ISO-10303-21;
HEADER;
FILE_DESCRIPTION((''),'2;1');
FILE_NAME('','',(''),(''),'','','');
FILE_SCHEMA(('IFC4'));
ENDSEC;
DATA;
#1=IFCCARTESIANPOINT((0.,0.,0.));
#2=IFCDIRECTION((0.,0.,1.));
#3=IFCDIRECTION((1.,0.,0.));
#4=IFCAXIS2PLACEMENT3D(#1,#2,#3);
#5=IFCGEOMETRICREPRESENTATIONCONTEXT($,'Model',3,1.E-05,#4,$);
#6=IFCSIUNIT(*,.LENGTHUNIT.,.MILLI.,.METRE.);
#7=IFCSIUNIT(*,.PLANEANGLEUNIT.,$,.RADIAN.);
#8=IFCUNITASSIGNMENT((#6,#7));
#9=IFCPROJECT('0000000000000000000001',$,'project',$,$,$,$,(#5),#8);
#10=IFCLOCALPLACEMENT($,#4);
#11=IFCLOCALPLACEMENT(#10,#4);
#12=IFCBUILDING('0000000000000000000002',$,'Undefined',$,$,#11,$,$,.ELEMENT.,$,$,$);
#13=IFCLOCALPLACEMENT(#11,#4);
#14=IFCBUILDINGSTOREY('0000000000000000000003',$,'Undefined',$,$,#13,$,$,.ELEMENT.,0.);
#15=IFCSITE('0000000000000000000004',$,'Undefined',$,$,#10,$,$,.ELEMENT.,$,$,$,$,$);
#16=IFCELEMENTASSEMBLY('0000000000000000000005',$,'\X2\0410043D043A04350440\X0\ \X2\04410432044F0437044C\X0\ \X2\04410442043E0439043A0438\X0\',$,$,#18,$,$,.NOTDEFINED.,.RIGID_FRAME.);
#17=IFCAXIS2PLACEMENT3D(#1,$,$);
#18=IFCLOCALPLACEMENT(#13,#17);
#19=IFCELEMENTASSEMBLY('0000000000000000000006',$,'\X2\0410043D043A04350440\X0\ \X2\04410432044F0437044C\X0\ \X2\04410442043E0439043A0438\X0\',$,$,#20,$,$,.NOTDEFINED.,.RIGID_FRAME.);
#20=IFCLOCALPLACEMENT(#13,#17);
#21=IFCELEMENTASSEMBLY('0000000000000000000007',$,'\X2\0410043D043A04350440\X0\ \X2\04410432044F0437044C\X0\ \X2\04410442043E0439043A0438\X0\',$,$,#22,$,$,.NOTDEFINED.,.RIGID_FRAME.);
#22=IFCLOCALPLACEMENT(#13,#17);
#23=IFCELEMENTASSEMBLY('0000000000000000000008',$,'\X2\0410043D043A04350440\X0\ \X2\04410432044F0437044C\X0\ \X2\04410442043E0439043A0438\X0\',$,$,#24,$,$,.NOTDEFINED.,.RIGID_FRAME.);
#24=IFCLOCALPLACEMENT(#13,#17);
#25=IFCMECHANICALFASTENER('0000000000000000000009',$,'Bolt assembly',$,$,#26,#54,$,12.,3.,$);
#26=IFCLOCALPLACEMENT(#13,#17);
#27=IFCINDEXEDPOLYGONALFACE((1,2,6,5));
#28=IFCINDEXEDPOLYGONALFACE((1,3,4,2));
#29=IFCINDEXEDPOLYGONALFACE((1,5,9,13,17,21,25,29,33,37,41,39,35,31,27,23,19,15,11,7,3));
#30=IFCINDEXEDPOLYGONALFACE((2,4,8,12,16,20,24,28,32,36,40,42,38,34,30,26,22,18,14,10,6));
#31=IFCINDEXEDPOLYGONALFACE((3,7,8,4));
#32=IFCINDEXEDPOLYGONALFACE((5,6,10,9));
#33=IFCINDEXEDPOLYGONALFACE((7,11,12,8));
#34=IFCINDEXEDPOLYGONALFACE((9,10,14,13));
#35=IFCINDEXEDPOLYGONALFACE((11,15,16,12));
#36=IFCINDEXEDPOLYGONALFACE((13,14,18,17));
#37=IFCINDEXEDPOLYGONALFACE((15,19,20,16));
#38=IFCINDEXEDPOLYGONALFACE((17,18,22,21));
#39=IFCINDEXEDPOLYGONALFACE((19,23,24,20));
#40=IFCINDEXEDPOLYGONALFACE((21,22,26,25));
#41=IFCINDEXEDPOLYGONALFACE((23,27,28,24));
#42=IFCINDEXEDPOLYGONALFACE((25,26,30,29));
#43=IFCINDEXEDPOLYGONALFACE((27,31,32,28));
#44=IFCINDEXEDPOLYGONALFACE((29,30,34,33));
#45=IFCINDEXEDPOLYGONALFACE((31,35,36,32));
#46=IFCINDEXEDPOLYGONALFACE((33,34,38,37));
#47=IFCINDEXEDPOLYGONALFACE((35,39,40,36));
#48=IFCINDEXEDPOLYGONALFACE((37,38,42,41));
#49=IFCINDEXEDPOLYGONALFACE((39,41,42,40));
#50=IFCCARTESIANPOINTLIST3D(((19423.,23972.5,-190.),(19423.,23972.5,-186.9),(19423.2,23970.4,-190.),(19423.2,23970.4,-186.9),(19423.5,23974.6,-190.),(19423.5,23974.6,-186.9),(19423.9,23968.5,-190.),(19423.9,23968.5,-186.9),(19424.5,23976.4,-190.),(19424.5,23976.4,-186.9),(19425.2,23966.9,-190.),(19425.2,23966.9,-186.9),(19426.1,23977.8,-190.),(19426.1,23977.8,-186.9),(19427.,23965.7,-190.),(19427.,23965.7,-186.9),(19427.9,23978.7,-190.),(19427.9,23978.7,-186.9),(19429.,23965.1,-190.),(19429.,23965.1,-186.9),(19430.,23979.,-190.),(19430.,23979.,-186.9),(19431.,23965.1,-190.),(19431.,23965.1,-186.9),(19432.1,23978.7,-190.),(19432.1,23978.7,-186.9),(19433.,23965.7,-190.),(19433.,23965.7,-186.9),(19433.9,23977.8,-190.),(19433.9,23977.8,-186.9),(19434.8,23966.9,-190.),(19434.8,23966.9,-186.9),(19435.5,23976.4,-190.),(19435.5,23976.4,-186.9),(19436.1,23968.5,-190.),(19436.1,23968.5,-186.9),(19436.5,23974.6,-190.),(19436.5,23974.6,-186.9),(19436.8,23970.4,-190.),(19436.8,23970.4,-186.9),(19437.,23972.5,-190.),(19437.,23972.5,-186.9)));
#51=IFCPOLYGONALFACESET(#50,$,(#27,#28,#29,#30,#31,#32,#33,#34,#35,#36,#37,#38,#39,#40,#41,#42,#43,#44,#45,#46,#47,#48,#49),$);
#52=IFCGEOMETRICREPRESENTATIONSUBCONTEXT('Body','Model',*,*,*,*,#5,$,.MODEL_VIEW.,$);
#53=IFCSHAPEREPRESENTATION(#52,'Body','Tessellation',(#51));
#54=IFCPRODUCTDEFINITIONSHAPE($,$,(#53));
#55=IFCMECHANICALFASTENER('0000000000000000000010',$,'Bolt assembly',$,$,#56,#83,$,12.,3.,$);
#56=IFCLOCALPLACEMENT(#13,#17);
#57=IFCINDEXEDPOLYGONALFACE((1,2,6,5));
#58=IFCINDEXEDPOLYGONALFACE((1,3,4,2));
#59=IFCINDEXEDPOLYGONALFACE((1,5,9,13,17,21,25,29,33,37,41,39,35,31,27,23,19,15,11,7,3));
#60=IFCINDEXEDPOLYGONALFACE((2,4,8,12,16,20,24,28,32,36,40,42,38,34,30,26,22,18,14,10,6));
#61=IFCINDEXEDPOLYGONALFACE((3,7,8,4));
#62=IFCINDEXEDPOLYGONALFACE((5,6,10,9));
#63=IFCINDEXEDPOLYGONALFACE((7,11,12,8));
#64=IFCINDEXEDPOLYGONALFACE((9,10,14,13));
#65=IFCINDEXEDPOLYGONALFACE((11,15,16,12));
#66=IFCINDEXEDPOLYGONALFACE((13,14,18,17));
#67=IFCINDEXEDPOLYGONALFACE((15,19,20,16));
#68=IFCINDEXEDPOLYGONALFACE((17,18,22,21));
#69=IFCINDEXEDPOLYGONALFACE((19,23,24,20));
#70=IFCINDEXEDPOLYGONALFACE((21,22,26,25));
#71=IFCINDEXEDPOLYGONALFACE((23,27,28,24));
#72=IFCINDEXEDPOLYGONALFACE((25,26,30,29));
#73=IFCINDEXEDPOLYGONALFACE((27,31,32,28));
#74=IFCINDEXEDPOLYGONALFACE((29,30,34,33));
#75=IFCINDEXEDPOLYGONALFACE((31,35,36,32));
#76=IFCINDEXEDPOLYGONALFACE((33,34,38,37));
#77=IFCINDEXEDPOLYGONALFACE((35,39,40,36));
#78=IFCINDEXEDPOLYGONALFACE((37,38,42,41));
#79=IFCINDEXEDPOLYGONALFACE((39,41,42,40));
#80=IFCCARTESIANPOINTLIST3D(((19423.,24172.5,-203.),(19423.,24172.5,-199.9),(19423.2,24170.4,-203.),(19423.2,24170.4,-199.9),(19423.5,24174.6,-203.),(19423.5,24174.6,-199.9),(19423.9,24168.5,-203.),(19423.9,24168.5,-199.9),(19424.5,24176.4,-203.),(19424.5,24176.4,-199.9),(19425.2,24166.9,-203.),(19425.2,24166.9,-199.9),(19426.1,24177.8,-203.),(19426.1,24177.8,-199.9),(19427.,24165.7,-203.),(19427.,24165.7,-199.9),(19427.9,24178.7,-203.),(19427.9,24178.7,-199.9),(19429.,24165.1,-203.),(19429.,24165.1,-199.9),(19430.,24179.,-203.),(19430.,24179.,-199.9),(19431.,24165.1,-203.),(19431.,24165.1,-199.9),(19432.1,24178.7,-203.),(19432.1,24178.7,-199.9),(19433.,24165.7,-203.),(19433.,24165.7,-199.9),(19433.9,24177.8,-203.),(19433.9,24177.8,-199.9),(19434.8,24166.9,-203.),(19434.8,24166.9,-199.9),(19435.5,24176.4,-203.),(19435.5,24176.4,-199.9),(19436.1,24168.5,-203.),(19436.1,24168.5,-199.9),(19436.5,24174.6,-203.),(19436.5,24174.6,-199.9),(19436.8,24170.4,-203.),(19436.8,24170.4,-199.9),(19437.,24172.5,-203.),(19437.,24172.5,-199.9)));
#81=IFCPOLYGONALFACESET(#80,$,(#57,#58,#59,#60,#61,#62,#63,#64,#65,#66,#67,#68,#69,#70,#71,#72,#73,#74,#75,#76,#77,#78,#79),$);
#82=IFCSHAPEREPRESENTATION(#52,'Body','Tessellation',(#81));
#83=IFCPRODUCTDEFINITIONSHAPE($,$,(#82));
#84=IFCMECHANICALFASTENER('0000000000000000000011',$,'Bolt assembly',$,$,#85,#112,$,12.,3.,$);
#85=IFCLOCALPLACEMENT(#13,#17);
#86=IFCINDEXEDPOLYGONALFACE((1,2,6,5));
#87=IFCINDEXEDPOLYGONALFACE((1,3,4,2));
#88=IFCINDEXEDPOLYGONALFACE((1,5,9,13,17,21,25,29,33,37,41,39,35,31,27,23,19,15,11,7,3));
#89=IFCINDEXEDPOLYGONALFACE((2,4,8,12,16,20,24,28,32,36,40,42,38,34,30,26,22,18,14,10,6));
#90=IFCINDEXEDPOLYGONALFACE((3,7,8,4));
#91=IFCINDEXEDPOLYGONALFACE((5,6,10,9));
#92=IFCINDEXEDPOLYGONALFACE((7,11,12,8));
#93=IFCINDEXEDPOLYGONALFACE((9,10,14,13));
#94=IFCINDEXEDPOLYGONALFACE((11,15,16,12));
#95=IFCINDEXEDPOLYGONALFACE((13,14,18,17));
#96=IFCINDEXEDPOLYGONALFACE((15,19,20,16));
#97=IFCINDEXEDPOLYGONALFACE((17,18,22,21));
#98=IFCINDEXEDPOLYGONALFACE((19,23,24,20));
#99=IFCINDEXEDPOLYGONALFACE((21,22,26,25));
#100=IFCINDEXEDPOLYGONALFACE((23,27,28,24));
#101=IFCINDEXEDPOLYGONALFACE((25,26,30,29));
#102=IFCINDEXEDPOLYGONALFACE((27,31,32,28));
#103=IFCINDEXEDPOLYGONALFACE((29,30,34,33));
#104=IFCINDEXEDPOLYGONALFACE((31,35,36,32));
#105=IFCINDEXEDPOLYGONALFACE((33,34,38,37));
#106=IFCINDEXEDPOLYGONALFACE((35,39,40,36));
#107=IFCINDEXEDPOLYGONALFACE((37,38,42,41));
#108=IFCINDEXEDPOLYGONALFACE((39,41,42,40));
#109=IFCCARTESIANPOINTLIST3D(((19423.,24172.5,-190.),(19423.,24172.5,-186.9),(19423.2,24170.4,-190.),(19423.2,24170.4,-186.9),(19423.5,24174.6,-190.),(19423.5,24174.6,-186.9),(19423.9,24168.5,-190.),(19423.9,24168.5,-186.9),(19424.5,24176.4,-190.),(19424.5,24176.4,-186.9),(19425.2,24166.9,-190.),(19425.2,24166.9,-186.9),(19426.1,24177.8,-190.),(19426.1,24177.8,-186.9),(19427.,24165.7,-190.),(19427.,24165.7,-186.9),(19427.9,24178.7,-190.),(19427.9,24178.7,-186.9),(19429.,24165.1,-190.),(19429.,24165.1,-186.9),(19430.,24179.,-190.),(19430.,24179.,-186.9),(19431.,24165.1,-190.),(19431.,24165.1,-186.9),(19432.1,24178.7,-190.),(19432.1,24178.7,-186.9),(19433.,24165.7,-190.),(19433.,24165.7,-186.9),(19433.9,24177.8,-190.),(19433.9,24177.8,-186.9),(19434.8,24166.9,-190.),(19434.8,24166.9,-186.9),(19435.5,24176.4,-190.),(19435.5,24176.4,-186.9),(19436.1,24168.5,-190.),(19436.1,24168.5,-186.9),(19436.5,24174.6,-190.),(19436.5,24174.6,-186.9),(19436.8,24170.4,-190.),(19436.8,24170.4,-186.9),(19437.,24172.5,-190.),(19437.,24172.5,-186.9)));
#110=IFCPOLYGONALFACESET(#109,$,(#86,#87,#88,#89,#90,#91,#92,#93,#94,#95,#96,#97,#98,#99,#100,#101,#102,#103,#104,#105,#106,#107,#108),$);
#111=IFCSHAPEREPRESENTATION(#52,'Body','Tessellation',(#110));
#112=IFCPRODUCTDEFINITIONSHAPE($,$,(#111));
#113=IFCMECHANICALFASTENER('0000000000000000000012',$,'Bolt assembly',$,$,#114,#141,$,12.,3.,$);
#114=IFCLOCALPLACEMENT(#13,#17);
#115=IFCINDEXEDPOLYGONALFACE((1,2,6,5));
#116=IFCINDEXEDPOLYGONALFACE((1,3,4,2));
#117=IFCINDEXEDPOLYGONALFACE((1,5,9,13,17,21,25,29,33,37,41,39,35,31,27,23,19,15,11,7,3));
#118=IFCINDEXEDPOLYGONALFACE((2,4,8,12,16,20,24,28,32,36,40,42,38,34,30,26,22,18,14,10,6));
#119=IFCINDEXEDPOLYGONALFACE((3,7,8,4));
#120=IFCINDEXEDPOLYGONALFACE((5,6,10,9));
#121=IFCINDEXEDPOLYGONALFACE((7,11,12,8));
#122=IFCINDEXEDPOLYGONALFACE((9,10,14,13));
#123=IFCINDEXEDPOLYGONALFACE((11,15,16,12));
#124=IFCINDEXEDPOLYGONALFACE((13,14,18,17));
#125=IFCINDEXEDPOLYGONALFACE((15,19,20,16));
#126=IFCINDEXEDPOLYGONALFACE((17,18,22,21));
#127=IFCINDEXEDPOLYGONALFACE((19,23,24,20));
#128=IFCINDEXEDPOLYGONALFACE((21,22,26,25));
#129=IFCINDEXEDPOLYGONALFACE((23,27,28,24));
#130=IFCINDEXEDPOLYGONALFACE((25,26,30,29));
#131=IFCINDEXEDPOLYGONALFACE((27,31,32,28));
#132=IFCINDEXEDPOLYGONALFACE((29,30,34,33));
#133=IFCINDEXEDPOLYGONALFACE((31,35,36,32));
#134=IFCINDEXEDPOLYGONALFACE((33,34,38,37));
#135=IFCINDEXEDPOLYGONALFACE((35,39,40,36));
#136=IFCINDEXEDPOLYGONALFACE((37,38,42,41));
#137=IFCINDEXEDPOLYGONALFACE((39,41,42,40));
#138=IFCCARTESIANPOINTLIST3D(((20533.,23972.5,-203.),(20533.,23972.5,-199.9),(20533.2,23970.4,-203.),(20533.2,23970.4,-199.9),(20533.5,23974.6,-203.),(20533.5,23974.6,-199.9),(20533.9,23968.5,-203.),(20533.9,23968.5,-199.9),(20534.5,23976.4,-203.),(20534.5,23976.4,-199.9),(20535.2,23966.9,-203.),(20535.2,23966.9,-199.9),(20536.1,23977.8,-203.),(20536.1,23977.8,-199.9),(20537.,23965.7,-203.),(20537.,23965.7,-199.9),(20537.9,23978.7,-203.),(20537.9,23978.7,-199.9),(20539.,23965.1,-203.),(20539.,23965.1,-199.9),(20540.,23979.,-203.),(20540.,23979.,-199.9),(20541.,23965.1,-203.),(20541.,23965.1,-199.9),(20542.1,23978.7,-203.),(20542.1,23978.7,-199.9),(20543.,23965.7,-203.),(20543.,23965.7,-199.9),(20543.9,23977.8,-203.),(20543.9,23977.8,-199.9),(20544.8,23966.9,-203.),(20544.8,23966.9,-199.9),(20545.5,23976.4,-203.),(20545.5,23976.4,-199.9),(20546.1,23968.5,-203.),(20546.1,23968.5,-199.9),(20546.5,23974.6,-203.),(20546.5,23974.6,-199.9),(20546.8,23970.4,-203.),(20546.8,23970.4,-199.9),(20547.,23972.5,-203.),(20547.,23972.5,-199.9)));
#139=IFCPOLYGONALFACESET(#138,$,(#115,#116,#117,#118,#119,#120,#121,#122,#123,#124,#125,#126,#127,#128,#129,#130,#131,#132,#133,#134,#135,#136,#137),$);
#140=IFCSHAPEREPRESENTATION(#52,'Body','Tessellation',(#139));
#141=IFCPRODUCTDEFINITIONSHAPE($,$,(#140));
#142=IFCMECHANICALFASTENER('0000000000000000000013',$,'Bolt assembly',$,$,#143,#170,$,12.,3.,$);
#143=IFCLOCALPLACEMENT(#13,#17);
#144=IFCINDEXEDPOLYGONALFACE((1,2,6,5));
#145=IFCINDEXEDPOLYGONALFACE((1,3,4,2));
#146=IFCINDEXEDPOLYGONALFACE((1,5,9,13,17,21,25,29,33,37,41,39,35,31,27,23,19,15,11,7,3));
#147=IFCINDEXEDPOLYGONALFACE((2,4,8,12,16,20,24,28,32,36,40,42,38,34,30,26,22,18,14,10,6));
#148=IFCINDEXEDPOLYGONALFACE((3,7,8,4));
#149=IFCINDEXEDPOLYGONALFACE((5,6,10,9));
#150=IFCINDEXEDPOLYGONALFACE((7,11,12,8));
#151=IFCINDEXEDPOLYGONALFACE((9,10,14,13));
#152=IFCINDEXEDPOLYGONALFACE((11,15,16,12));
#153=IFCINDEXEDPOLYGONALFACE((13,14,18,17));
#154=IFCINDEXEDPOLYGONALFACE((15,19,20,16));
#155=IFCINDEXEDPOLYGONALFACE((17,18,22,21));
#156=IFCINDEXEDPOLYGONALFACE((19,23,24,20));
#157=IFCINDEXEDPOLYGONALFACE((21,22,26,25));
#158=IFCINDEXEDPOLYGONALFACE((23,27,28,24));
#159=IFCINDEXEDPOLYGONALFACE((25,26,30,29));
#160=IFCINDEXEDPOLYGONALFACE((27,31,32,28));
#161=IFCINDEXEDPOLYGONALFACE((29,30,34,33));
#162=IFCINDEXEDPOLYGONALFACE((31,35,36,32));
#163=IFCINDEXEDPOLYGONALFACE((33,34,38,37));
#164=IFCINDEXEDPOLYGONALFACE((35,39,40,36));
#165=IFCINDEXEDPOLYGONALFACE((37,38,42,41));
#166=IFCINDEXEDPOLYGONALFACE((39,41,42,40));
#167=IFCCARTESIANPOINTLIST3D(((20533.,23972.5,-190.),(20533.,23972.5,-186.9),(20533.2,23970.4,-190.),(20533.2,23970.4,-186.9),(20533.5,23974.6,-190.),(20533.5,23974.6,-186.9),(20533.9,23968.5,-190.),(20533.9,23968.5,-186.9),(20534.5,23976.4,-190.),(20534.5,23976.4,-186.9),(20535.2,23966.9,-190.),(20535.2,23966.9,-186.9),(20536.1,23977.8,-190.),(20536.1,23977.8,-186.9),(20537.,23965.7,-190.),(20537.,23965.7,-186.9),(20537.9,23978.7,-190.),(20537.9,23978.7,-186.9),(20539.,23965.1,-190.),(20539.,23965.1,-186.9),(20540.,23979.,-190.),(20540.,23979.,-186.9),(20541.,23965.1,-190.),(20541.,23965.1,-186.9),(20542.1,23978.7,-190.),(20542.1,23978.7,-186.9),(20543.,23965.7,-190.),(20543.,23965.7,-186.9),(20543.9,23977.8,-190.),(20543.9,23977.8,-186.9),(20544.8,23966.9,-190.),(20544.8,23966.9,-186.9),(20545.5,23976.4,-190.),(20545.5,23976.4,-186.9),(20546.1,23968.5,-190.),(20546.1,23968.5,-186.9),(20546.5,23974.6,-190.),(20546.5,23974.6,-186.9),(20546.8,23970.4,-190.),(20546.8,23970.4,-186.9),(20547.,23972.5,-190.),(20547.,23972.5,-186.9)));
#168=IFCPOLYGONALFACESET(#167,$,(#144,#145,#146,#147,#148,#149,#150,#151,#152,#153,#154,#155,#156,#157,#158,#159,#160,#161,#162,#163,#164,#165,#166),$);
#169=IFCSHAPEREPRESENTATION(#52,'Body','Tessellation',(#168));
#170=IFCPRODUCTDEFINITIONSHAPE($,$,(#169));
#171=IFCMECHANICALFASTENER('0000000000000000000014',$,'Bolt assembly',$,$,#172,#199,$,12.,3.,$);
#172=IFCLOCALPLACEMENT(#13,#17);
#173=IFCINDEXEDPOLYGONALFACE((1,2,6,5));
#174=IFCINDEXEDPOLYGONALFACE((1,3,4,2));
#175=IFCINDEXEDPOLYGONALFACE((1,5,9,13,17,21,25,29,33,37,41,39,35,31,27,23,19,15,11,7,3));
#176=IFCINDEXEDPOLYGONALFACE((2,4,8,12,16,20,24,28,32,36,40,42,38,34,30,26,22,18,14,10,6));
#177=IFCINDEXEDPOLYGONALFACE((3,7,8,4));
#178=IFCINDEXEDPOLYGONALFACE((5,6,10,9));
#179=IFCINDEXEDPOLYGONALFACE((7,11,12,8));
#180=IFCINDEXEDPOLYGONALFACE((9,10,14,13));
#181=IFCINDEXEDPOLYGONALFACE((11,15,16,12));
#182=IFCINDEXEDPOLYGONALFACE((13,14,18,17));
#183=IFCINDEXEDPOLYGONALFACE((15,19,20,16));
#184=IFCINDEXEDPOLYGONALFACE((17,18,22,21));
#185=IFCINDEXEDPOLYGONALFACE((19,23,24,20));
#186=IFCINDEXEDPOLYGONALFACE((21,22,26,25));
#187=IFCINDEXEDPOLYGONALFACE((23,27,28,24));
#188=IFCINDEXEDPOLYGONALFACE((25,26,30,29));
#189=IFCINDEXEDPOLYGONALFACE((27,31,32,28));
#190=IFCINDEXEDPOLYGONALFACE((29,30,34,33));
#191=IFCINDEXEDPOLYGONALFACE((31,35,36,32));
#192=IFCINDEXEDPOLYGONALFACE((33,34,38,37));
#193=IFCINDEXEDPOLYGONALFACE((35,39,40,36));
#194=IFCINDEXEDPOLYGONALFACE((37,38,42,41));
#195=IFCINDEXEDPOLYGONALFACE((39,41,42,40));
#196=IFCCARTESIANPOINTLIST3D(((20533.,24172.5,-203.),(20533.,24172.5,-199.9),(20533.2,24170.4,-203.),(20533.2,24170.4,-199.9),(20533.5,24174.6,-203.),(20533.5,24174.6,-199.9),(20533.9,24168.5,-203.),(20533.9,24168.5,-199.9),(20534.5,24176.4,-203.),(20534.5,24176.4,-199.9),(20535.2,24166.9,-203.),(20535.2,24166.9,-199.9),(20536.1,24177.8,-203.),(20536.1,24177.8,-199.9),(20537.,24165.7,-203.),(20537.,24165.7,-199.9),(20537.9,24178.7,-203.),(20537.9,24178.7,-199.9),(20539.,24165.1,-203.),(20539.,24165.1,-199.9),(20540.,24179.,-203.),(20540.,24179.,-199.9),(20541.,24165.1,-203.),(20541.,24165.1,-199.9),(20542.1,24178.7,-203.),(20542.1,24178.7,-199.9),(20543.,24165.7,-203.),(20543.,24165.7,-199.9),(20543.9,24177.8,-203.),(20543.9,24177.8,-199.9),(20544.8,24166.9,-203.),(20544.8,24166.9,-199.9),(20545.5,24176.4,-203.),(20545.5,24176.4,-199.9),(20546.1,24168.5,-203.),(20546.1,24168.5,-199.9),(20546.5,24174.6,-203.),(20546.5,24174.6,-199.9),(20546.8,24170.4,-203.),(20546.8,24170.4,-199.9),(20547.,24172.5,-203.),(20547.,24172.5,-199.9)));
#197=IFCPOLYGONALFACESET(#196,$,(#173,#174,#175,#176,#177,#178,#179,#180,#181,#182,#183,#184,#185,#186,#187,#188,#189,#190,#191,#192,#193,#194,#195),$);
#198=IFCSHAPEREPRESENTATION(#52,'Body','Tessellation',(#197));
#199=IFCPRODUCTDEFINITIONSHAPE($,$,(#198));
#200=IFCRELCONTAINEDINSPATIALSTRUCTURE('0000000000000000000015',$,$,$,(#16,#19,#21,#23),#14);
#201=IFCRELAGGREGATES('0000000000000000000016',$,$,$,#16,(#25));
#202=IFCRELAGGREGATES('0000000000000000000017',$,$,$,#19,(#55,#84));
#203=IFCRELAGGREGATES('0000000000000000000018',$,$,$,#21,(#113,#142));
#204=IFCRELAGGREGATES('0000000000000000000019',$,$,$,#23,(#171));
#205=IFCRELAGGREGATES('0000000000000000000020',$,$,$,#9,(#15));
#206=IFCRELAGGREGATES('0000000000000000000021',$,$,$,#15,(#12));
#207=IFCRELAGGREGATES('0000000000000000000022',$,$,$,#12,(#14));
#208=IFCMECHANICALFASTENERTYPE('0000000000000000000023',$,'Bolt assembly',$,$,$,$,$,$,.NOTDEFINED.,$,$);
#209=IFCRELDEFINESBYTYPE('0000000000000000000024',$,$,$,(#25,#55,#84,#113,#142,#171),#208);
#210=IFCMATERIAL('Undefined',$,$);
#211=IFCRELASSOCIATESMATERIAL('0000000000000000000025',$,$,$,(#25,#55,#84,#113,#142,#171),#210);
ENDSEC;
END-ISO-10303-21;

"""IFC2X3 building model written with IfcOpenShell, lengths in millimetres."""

from ifc_helpers import new_model, si_unit, frame, origin_with_axes, origin_2d_with_axis, place, context, subcontext, project, spatial, circle, extrude, source, transform, mapped, material, type_object, element, aggregate, save


model = new_model("IFC2X3")

# Units and contexts
model_context = context("Model", 3, precision=1e-05, world=origin_with_axes())
body_context = subcontext(model_context, "Body", "Model", "MODEL_VIEW")
ifc_project = project(units=[si_unit("LENGTHUNIT", "METRE", prefix="MILLI"), si_unit("PLANEANGLEUNIT", "RADIAN")], contexts=[model_context])

# Site, building, storey
site_placement = place(None, origin_with_axes())
site = spatial("IfcSite", under=ifc_project, at=site_placement, Name="Undefined", CompositionType="ELEMENT")
building_placement = place(site_placement, origin_with_axes())
building = spatial("IfcBuilding", under=site, at=building_placement, Name="Undefined", CompositionType="ELEMENT")
storey_placement = place(building_placement, origin_with_axes())
storey = spatial("IfcBuildingStorey", under=building, at=storey_placement, Name="Undefined", CompositionType="ELEMENT", Elevation=0.0)

# Element assemblies
assembly_1_placement = place(storey_placement, origin_with_axes())
assembly_1 = element("IfcElementAssembly", 1, at=assembly_1_placement, inside=storey, Name="Анкер связь стойки", AssemblyPlace="NOTDEFINED", PredefinedType="RIGID_FRAME")
assembly_2_placement = place(storey_placement, origin_with_axes())
assembly_2 = element("IfcElementAssembly", 2, at=assembly_2_placement, inside=storey, Name="Анкер связь стойки", AssemblyPlace="NOTDEFINED", PredefinedType="RIGID_FRAME")
assembly_3_placement = place(storey_placement, origin_with_axes())
assembly_3 = element("IfcElementAssembly", 3, at=assembly_3_placement, inside=storey, Name="Анкер связь стойки", AssemblyPlace="NOTDEFINED", PredefinedType="RIGID_FRAME")
assembly_4_placement = place(storey_placement, origin_with_axes())
assembly_4 = element("IfcElementAssembly", 4, at=assembly_4_placement, inside=storey, Name="Анкер связь стойки", AssemblyPlace="NOTDEFINED", PredefinedType="RIGID_FRAME")

# Mechanical fasteners
ifc_material_1 = material(Name="Undefined")
mechanical_fastener_type = type_object("IfcMechanicalFastenerType", Name="Bolt assembly")
shared_shape_1 = source(origin_with_axes(), body_context, "Body", "SweptSolid", [
    extrude(circle(Radius=7.0, at=origin_2d_with_axis()), frame((0.0, -3.0, 0.0), z_axis=(0.0, 1.0, 0.0), x_axis=(1.0, 0.0, 0.0)), (0.0, 0.0, 1.0), 3.1),
])
mechanical_fastener_1_placement = place(assembly_1_placement, frame((19430.0, 23972.0, -187.0), z_axis=(1.0, 0.0, 0.0), x_axis=(0.0, 1.0, 0.0)))
mechanical_fastener_1 = element("IfcMechanicalFastener", 5, at=mechanical_fastener_1_placement, type_object=mechanical_fastener_type, material=ifc_material_1, Name="Bolt assembly", NominalDiameter=12.0, NominalLength=3.0, context=body_context, shape_type="MappedRepresentation", body=[
    mapped(shared_shape_1, transform((0.0, 0.0, 0.0))),
])
aggregate(assembly_1, [mechanical_fastener_1])
mechanical_fastener_2_placement = place(assembly_2_placement, frame((19430.0, 24172.0, -200.0), z_axis=(1.0, 0.0, 0.0), x_axis=(0.0, 1.0, 0.0)))
mechanical_fastener_2 = element("IfcMechanicalFastener", 6, at=mechanical_fastener_2_placement, type_object=mechanical_fastener_type, material=ifc_material_1, Name="Bolt assembly", NominalDiameter=12.0, NominalLength=3.0, context=body_context, shape_type="MappedRepresentation", body=[
    mapped(shared_shape_1, transform((0.0, 0.0, 0.0))),
])
mechanical_fastener_3_placement = place(assembly_2_placement, frame((19430.0, 24172.0, -187.0), z_axis=(1.0, 0.0, 0.0), x_axis=(0.0, 1.0, 0.0)))
mechanical_fastener_3 = element("IfcMechanicalFastener", 7, at=mechanical_fastener_3_placement, type_object=mechanical_fastener_type, material=ifc_material_1, Name="Bolt assembly", NominalDiameter=12.0, NominalLength=3.0, context=body_context, shape_type="MappedRepresentation", body=[
    mapped(shared_shape_1, transform((0.0, 0.0, 0.0))),
])
aggregate(assembly_2, [mechanical_fastener_2, mechanical_fastener_3])
mechanical_fastener_4_placement = place(assembly_3_placement, frame((20540.0, 23972.0, -200.0), z_axis=(1.0, 0.0, 0.0), x_axis=(0.0, 1.0, 0.0)))
mechanical_fastener_4 = element("IfcMechanicalFastener", 8, at=mechanical_fastener_4_placement, type_object=mechanical_fastener_type, material=ifc_material_1, Name="Bolt assembly", NominalDiameter=12.0, NominalLength=3.0, context=body_context, shape_type="MappedRepresentation", body=[
    mapped(shared_shape_1, transform((0.0, 0.0, 0.0))),
])
mechanical_fastener_5_placement = place(assembly_3_placement, frame((20540.0, 23972.0, -187.0), z_axis=(1.0, 0.0, 0.0), x_axis=(0.0, 1.0, 0.0)))
mechanical_fastener_5 = element("IfcMechanicalFastener", 9, at=mechanical_fastener_5_placement, type_object=mechanical_fastener_type, material=ifc_material_1, Name="Bolt assembly", NominalDiameter=12.0, NominalLength=3.0, context=body_context, shape_type="MappedRepresentation", body=[
    mapped(shared_shape_1, transform((0.0, 0.0, 0.0))),
])
aggregate(assembly_3, [mechanical_fastener_4, mechanical_fastener_5])
mechanical_fastener_6_placement = place(assembly_4_placement, frame((20540.0, 24172.0, -200.0), z_axis=(1.0, 0.0, 0.0), x_axis=(0.0, 1.0, 0.0)))
mechanical_fastener_6 = element("IfcMechanicalFastener", 10, at=mechanical_fastener_6_placement, type_object=mechanical_fastener_type, material=ifc_material_1, Name="Bolt assembly", NominalDiameter=12.0, NominalLength=3.0, context=body_context, shape_type="MappedRepresentation", body=[
    mapped(shared_shape_1, transform((0.0, 0.0, 0.0))),
])
aggregate(assembly_4, [mechanical_fastener_6])

save(model, "model.ifc")
